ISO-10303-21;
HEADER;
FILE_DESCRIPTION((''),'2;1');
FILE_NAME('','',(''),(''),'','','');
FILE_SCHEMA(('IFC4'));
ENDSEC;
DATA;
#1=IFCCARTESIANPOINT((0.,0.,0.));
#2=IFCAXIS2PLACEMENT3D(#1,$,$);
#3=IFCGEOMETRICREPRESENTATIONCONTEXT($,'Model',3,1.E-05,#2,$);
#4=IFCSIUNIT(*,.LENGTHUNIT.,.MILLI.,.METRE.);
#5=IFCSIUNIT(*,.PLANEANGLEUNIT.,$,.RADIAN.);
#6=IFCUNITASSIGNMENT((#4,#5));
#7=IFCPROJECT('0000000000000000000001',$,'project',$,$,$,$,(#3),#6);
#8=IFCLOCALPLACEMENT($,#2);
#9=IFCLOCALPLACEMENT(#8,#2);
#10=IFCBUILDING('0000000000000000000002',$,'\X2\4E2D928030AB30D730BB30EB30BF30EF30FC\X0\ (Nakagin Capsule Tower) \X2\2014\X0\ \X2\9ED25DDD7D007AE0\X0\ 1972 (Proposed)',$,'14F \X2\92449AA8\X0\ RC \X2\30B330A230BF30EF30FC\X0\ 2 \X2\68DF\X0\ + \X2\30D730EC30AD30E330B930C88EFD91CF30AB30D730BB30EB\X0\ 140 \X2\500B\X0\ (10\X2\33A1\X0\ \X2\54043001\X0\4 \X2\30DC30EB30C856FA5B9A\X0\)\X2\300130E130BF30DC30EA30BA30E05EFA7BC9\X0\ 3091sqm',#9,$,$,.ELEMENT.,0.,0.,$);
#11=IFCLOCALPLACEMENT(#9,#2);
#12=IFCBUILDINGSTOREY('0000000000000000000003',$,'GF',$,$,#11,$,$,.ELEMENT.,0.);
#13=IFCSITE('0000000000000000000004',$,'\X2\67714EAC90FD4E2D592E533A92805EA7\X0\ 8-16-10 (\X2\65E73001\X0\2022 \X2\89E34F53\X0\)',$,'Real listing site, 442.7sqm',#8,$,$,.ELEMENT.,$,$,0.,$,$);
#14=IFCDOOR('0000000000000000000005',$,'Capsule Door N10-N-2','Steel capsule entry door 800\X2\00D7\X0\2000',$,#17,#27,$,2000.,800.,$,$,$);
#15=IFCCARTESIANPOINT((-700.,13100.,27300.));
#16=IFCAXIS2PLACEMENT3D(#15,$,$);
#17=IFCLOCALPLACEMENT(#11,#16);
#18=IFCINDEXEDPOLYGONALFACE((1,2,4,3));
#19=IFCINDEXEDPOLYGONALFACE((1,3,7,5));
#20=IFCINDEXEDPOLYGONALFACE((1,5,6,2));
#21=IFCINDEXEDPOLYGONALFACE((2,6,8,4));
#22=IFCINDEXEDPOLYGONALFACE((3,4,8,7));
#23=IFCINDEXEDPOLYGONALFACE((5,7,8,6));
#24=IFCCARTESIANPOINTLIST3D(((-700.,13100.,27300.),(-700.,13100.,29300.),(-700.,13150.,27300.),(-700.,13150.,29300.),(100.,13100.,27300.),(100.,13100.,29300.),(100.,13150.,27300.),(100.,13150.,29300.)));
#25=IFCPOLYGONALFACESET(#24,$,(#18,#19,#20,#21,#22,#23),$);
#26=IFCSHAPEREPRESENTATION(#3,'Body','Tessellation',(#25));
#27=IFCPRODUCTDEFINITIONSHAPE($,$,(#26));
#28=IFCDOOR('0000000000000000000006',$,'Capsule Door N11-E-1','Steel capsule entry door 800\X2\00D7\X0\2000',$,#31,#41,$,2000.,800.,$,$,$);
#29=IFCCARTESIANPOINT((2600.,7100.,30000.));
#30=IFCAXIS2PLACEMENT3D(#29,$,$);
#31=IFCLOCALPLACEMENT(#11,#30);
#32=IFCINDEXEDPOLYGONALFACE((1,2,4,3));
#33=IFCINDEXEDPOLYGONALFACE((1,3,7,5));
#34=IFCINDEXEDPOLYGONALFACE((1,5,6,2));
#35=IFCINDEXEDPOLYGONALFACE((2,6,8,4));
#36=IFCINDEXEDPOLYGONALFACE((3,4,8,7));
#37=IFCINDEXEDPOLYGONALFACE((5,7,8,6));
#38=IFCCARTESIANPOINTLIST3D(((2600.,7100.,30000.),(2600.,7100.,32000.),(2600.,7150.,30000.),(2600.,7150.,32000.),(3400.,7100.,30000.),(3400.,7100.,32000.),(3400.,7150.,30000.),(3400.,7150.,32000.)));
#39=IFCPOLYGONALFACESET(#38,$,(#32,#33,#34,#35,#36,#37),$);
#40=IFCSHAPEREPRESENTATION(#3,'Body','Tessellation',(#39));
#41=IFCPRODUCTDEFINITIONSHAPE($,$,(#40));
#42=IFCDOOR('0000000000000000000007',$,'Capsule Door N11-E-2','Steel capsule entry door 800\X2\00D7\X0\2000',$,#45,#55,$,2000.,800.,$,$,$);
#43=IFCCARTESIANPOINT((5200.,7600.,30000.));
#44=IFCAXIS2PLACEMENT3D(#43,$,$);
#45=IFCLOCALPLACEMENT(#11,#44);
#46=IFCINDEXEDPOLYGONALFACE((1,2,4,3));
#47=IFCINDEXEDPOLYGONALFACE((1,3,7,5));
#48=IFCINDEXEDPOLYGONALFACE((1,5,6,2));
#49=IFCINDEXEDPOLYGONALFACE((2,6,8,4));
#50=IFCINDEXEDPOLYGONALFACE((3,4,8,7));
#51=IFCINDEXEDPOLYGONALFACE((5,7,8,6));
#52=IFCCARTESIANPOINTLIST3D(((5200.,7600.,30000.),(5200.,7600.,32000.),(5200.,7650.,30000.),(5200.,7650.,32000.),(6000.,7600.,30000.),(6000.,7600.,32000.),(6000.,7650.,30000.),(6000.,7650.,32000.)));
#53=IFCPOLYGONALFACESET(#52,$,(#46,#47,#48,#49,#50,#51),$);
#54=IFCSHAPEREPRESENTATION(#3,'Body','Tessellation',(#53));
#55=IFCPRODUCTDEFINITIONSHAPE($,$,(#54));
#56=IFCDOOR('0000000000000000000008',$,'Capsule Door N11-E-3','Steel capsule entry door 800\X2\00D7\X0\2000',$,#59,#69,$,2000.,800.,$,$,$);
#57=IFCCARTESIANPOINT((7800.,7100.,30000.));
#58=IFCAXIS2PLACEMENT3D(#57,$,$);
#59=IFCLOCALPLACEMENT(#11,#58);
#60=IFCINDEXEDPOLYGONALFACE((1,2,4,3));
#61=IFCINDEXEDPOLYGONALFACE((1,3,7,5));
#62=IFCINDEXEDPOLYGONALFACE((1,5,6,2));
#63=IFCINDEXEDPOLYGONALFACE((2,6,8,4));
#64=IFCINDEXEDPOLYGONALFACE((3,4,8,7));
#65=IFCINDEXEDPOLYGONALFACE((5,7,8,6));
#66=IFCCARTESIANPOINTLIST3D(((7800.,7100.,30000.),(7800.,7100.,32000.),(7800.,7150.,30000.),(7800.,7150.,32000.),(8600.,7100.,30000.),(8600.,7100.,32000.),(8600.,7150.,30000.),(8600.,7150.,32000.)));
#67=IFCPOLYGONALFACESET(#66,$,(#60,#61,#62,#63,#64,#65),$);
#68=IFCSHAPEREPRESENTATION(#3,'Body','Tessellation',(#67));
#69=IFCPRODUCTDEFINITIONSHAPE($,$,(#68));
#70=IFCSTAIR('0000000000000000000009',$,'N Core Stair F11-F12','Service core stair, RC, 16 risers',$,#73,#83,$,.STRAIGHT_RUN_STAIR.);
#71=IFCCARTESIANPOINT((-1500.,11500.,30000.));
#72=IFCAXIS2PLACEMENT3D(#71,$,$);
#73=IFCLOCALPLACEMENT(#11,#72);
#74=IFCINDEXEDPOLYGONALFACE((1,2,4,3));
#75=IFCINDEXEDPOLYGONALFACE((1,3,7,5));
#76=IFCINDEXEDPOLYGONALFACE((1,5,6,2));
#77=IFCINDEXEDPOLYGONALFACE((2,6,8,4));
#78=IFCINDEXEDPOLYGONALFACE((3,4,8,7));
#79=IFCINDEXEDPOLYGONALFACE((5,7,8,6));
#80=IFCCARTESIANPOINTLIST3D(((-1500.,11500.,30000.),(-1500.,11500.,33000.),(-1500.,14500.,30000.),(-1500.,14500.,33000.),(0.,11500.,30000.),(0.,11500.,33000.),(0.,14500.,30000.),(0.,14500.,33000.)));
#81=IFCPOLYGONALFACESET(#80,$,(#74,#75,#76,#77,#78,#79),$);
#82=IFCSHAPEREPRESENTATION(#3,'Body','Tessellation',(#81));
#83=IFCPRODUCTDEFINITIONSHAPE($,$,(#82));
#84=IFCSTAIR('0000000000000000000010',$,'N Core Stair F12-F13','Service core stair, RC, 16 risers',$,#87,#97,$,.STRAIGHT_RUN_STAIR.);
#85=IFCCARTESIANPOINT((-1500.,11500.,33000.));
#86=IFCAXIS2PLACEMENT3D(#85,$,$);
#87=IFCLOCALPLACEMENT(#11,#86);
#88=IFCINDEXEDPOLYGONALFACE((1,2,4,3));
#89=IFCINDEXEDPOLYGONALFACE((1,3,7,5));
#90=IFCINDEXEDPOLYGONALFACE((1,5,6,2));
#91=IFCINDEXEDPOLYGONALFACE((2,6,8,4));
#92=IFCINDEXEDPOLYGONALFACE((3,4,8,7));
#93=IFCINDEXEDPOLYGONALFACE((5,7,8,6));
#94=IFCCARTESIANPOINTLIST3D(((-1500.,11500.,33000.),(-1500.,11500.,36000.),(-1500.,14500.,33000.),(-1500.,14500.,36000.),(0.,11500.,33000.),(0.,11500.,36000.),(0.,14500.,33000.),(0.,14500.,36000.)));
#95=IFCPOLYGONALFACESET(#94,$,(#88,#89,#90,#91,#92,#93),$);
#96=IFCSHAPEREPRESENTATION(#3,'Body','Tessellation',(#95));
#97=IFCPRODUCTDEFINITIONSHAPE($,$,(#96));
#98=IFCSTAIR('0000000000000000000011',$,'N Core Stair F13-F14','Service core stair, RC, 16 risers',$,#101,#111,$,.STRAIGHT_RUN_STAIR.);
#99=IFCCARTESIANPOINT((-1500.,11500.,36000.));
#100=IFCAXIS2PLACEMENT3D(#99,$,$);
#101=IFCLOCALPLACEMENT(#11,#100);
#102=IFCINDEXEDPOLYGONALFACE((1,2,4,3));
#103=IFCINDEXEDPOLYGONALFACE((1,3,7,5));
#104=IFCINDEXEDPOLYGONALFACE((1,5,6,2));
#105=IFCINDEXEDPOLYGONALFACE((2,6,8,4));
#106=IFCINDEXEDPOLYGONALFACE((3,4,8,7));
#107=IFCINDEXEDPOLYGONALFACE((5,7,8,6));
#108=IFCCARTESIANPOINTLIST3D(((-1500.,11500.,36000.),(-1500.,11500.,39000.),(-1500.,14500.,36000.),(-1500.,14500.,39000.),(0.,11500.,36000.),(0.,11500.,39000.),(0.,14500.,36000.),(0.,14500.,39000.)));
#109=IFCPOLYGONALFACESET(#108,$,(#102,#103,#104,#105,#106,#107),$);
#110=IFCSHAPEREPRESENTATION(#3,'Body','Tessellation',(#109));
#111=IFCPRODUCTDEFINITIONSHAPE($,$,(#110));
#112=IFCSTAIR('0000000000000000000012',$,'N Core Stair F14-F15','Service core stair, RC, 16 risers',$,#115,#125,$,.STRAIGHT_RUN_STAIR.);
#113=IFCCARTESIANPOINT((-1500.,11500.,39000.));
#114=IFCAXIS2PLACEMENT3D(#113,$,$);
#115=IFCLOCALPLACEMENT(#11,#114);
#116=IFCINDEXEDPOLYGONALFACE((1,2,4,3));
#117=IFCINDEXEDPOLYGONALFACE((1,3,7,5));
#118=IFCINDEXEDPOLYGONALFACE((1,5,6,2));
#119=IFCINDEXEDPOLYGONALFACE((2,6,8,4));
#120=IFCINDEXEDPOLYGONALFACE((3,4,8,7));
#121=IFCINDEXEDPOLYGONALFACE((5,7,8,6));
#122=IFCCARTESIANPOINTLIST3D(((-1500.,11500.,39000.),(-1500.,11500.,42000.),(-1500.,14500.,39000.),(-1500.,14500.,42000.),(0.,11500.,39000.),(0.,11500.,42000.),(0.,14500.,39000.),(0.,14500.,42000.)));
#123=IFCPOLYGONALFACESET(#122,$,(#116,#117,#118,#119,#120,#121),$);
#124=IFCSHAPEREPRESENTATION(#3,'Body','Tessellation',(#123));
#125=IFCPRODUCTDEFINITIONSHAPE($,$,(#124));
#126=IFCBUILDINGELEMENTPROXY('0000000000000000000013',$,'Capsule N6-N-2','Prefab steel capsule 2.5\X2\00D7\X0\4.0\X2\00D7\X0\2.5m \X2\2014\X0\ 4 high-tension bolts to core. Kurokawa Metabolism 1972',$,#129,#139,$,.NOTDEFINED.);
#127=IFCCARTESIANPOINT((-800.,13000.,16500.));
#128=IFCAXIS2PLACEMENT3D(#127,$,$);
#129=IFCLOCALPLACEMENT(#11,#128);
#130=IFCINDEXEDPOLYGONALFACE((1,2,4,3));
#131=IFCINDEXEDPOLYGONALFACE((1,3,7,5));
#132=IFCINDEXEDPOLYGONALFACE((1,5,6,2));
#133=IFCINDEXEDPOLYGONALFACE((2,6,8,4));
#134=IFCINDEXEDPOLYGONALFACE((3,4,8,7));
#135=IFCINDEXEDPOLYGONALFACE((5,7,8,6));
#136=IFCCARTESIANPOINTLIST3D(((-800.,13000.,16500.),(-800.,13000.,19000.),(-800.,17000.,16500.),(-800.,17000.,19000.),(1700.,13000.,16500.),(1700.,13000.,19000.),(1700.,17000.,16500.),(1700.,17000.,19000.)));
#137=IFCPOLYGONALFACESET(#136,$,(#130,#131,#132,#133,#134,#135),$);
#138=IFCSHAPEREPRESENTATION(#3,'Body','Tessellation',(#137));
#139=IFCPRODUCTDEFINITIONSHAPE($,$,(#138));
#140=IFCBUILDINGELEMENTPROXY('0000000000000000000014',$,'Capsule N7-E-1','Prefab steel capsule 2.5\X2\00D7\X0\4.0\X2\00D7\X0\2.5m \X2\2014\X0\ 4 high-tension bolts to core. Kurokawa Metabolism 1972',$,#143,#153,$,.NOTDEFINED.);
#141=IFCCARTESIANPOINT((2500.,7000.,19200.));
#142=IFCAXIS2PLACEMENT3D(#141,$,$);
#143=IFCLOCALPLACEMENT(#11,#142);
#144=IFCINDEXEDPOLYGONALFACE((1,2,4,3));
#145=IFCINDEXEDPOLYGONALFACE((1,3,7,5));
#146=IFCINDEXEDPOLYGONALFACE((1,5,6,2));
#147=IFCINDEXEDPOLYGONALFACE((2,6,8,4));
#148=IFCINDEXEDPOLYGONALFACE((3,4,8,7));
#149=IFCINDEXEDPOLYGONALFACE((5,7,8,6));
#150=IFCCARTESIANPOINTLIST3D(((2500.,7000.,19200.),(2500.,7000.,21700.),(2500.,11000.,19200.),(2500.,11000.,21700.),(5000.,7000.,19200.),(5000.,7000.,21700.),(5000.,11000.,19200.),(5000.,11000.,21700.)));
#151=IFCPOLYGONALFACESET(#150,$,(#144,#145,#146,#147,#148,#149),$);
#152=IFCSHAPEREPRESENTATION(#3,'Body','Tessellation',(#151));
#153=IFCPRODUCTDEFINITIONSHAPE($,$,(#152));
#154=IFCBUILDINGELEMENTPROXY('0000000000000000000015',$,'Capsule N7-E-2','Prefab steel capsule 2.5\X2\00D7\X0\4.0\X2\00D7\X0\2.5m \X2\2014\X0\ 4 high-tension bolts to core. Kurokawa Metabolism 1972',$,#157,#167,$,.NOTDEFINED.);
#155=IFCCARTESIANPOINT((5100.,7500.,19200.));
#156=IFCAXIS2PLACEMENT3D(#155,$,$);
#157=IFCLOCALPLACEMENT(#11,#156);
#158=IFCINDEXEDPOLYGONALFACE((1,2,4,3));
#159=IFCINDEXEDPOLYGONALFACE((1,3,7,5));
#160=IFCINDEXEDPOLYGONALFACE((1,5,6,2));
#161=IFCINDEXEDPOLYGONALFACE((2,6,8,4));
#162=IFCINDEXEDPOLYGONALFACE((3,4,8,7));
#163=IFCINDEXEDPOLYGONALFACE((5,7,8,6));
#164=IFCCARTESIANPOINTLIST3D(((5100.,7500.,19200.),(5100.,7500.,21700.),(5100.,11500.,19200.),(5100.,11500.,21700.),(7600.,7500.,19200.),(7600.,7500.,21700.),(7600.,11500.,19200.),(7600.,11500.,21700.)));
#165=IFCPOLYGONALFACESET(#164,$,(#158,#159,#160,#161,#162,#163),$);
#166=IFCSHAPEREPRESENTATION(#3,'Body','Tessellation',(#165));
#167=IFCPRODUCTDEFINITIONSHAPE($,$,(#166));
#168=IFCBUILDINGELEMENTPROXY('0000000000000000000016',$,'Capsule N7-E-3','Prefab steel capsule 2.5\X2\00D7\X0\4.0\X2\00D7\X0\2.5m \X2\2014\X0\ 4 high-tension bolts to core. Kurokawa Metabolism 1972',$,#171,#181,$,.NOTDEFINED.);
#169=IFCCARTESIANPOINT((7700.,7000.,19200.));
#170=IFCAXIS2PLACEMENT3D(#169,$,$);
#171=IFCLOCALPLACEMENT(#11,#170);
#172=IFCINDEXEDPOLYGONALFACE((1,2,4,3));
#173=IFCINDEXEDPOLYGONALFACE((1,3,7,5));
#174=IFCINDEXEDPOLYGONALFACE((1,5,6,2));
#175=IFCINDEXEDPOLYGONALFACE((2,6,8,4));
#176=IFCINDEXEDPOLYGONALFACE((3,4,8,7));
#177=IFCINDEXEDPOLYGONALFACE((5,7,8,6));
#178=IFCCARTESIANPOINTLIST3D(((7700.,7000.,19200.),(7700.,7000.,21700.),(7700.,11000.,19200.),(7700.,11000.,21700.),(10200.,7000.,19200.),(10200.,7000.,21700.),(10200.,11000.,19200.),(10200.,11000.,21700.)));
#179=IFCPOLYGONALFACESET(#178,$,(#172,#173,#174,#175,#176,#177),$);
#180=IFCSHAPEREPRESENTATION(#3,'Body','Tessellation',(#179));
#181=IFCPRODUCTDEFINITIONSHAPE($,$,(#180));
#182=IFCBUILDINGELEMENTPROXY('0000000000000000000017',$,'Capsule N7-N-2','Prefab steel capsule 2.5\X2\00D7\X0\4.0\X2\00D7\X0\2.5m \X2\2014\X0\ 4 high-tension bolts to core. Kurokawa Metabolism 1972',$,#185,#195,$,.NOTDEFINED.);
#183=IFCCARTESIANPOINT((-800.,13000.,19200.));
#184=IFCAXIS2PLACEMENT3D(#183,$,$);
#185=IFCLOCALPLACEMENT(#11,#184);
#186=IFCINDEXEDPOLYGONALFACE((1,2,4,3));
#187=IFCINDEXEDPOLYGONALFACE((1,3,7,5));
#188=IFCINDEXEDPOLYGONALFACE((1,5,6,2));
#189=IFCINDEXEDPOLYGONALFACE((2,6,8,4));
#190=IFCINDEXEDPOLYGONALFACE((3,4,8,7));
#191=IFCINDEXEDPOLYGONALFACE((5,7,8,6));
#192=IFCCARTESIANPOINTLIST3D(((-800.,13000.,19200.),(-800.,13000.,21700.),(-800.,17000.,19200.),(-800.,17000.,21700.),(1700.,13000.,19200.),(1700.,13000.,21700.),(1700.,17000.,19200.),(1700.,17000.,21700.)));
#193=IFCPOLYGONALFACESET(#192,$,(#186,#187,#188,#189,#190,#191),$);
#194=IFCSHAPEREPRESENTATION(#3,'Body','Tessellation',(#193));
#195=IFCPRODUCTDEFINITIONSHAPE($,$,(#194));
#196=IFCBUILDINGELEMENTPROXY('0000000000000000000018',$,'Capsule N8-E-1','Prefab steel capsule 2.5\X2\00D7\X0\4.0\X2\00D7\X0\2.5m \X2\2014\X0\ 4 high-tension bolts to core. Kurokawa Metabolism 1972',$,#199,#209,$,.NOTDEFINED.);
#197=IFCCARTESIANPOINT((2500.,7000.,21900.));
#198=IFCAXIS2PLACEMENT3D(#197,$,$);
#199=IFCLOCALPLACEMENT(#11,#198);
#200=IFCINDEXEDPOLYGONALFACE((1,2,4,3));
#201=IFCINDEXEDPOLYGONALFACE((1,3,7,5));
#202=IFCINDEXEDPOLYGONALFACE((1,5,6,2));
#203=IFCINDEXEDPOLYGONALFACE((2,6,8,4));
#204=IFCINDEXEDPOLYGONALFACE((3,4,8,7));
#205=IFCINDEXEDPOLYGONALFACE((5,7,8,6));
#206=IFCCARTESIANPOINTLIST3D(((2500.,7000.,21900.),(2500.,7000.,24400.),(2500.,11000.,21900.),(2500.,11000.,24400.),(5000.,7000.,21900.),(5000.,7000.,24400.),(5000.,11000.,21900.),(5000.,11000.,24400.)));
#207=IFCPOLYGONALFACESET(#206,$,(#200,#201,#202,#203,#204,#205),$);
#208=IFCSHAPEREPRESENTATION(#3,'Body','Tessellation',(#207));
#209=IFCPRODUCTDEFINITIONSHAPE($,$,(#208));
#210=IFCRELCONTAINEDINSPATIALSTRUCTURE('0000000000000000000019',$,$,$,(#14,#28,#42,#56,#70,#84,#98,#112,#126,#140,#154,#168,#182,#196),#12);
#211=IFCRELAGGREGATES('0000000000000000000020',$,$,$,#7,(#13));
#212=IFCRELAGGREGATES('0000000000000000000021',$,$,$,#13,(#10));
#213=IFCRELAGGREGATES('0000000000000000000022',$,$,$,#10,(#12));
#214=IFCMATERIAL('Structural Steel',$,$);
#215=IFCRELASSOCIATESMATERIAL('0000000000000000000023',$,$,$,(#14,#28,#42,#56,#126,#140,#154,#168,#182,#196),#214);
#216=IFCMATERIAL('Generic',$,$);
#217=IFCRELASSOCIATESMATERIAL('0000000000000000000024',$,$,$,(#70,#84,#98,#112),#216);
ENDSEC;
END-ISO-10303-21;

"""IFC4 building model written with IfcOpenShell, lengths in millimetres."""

from ifc_helpers import new_model, si_unit, frame, frame_2d, origin, place, context, project, spatial, rectangle, extrude, material, element, save


model = new_model("IFC4")

# Units and contexts
model_context = context("Model", 3, precision=1e-05, world=origin())
ifc_project = project(units=[si_unit("LENGTHUNIT", "METRE", prefix="MILLI"), si_unit("PLANEANGLEUNIT", "RADIAN")], contexts=[model_context])

# Site, building, storey
site_placement = place(None, origin())
site = spatial("IfcSite", under=ifc_project, at=site_placement, Name="東京都中央区銀座 8-16-10 (旧、2022 解体)", ObjectType="Real listing site, 442.7sqm", CompositionType="ELEMENT", RefElevation=0.0)
building_placement = place(site_placement, origin())
building = spatial("IfcBuilding", under=site, at=building_placement, Name="中銀カプセルタワー (Nakagin Capsule Tower) — 黒川紀章 1972 (Proposed)", ObjectType="14F 鉄骨 RC コアタワー 2 棟 + プレキャスト軽量カプセル 140 個 (10㎡ 各、4 ボルト固定)、メタボリズム建築 3091sqm", CompositionType="ELEMENT", ElevationOfRefHeight=0.0, ElevationOfTerrain=0.0)
storey_placement = place(building_placement, origin())
storey = spatial("IfcBuildingStorey", under=building, at=storey_placement, Name="GF", CompositionType="ELEMENT", Elevation=0.0)

# Doors
ifc_material_1 = material(Name="Structural Steel")
door_1_placement = place(storey_placement, frame((-700.0, 13100.0, 27300.0)))
element("IfcDoor", 1, at=door_1_placement, inside=storey, material=ifc_material_1, Name="Capsule Door N10-N-2", Description="Steel capsule entry door 800×2000", OverallHeight=2000.0, OverallWidth=800.0, context=model_context, shape_type="SweptSolid", body=[
    extrude(rectangle(XDim=800.0, YDim=50.0, at=frame_2d((400.0, 25.0))), frame((-700.0, 13100.0, 27300.0)), (0.0, 0.0, 1.0), 2000.0),
])
door_2_placement = place(storey_placement, frame((2600.0, 7100.0, 30000.0)))
element("IfcDoor", 2, at=door_2_placement, inside=storey, material=ifc_material_1, Name="Capsule Door N11-E-1", Description="Steel capsule entry door 800×2000", OverallHeight=2000.0, OverallWidth=800.0, context=model_context, shape_type="SweptSolid", body=[
    extrude(rectangle(XDim=800.0, YDim=50.0, at=frame_2d((400.0, 25.0))), frame((2600.0, 7100.0, 30000.0)), (0.0, 0.0, 1.0), 2000.0),
])
door_3_placement = place(storey_placement, frame((5200.0, 7600.0, 30000.0)))
element("IfcDoor", 3, at=door_3_placement, inside=storey, material=ifc_material_1, Name="Capsule Door N11-E-2", Description="Steel capsule entry door 800×2000", OverallHeight=2000.0, OverallWidth=800.0, context=model_context, shape_type="SweptSolid", body=[
    extrude(rectangle(XDim=800.0, YDim=50.0, at=frame_2d((400.0, 25.0))), frame((5200.0, 7600.0, 30000.0)), (0.0, 0.0, 1.0), 2000.0),
])
door_4_placement = place(storey_placement, frame((7800.0, 7100.0, 30000.0)))
element("IfcDoor", 4, at=door_4_placement, inside=storey, material=ifc_material_1, Name="Capsule Door N11-E-3", Description="Steel capsule entry door 800×2000", OverallHeight=2000.0, OverallWidth=800.0, context=model_context, shape_type="SweptSolid", body=[
    extrude(rectangle(XDim=800.0, YDim=50.0, at=frame_2d((400.0, 25.0))), frame((7800.0, 7100.0, 30000.0)), (0.0, 0.0, 1.0), 2000.0),
])

# Stairs
ifc_material_2 = material(Name="Generic")
stair_1_placement = place(storey_placement, frame((-1500.0, 11500.0, 30000.0)))
element("IfcStair", 5, at=stair_1_placement, inside=storey, material=ifc_material_2, Name="N Core Stair F11-F12", Description="Service core stair, RC, 16 risers", PredefinedType="STRAIGHT_RUN_STAIR", context=model_context, shape_type="SweptSolid", body=[
    extrude(rectangle(XDim=1500.0, YDim=3000.0, at=frame_2d((750.0, 1500.0))), frame((-1500.0, 11500.0, 30000.0)), (0.0, 0.0, 1.0), 3000.0),
])
stair_2_placement = place(storey_placement, frame((-1500.0, 11500.0, 33000.0)))
element("IfcStair", 6, at=stair_2_placement, inside=storey, material=ifc_material_2, Name="N Core Stair F12-F13", Description="Service core stair, RC, 16 risers", PredefinedType="STRAIGHT_RUN_STAIR", context=model_context, shape_type="SweptSolid", body=[
    extrude(rectangle(XDim=1500.0, YDim=3000.0, at=frame_2d((750.0, 1500.0))), frame((-1500.0, 11500.0, 33000.0)), (0.0, 0.0, 1.0), 3000.0),
])
stair_3_placement = place(storey_placement, frame((-1500.0, 11500.0, 36000.0)))
element("IfcStair", 7, at=stair_3_placement, inside=storey, material=ifc_material_2, Name="N Core Stair F13-F14", Description="Service core stair, RC, 16 risers", PredefinedType="STRAIGHT_RUN_STAIR", context=model_context, shape_type="SweptSolid", body=[
    extrude(rectangle(XDim=1500.0, YDim=3000.0, at=frame_2d((750.0, 1500.0))), frame((-1500.0, 11500.0, 36000.0)), (0.0, 0.0, 1.0), 3000.0),
])
stair_4_placement = place(storey_placement, frame((-1500.0, 11500.0, 39000.0)))
element("IfcStair", 8, at=stair_4_placement, inside=storey, material=ifc_material_2, Name="N Core Stair F14-F15", Description="Service core stair, RC, 16 risers", PredefinedType="STRAIGHT_RUN_STAIR", context=model_context, shape_type="SweptSolid", body=[
    extrude(rectangle(XDim=1500.0, YDim=3000.0, at=frame_2d((750.0, 1500.0))), frame((-1500.0, 11500.0, 39000.0)), (0.0, 0.0, 1.0), 3000.0),
])

# Building element proxies
proxy_1_placement = place(storey_placement, frame((-800.0, 13000.0, 16500.0)))
element("IfcBuildingElementProxy", 9, at=proxy_1_placement, inside=storey, material=ifc_material_1, Name="Capsule N6-N-2", Description="Prefab steel capsule 2.5×4.0×2.5m — 4 high-tension bolts to core. Kurokawa Metabolism 1972", PredefinedType="NOTDEFINED", context=model_context, shape_type="SweptSolid", body=[
    extrude(rectangle(XDim=2500.0, YDim=4000.0, at=frame_2d((1250.0, 2000.0))), frame((-800.0, 13000.0, 16500.0)), (0.0, 0.0, 1.0), 2500.0),
])
proxy_2_placement = place(storey_placement, frame((2500.0, 7000.0, 19200.0)))
element("IfcBuildingElementProxy", 10, at=proxy_2_placement, inside=storey, material=ifc_material_1, Name="Capsule N7-E-1", Description="Prefab steel capsule 2.5×4.0×2.5m — 4 high-tension bolts to core. Kurokawa Metabolism 1972", PredefinedType="NOTDEFINED", context=model_context, shape_type="SweptSolid", body=[
    extrude(rectangle(XDim=2500.0, YDim=4000.0, at=frame_2d((1250.0, 2000.0))), frame((2500.0, 7000.0, 19200.0)), (0.0, 0.0, 1.0), 2500.0),
])
proxy_3_placement = place(storey_placement, frame((5100.0, 7500.0, 19200.0)))
element("IfcBuildingElementProxy", 11, at=proxy_3_placement, inside=storey, material=ifc_material_1, Name="Capsule N7-E-2", Description="Prefab steel capsule 2.5×4.0×2.5m — 4 high-tension bolts to core. Kurokawa Metabolism 1972", PredefinedType="NOTDEFINED", context=model_context, shape_type="SweptSolid", body=[
    extrude(rectangle(XDim=2500.0, YDim=4000.0, at=frame_2d((1250.0, 2000.0))), frame((5100.0, 7500.0, 19200.0)), (0.0, 0.0, 1.0), 2500.0),
])
proxy_4_placement = place(storey_placement, frame((7700.0, 7000.0, 19200.0)))
element("IfcBuildingElementProxy", 12, at=proxy_4_placement, inside=storey, material=ifc_material_1, Name="Capsule N7-E-3", Description="Prefab steel capsule 2.5×4.0×2.5m — 4 high-tension bolts to core. Kurokawa Metabolism 1972", PredefinedType="NOTDEFINED", context=model_context, shape_type="SweptSolid", body=[
    extrude(rectangle(XDim=2500.0, YDim=4000.0, at=frame_2d((1250.0, 2000.0))), frame((7700.0, 7000.0, 19200.0)), (0.0, 0.0, 1.0), 2500.0),
])
proxy_5_placement = place(storey_placement, frame((-800.0, 13000.0, 19200.0)))
element("IfcBuildingElementProxy", 13, at=proxy_5_placement, inside=storey, material=ifc_material_1, Name="Capsule N7-N-2", Description="Prefab steel capsule 2.5×4.0×2.5m — 4 high-tension bolts to core. Kurokawa Metabolism 1972", PredefinedType="NOTDEFINED", context=model_context, shape_type="SweptSolid", body=[
    extrude(rectangle(XDim=2500.0, YDim=4000.0, at=frame_2d((1250.0, 2000.0))), frame((-800.0, 13000.0, 19200.0)), (0.0, 0.0, 1.0), 2500.0),
])
proxy_6_placement = place(storey_placement, frame((2500.0, 7000.0, 21900.0)))
element("IfcBuildingElementProxy", 14, at=proxy_6_placement, inside=storey, material=ifc_material_1, Name="Capsule N8-E-1", Description="Prefab steel capsule 2.5×4.0×2.5m — 4 high-tension bolts to core. Kurokawa Metabolism 1972", PredefinedType="NOTDEFINED", context=model_context, shape_type="SweptSolid", body=[
    extrude(rectangle(XDim=2500.0, YDim=4000.0, at=frame_2d((1250.0, 2000.0))), frame((2500.0, 7000.0, 21900.0)), (0.0, 0.0, 1.0), 2500.0),
])

save(model, "model.ifc")
